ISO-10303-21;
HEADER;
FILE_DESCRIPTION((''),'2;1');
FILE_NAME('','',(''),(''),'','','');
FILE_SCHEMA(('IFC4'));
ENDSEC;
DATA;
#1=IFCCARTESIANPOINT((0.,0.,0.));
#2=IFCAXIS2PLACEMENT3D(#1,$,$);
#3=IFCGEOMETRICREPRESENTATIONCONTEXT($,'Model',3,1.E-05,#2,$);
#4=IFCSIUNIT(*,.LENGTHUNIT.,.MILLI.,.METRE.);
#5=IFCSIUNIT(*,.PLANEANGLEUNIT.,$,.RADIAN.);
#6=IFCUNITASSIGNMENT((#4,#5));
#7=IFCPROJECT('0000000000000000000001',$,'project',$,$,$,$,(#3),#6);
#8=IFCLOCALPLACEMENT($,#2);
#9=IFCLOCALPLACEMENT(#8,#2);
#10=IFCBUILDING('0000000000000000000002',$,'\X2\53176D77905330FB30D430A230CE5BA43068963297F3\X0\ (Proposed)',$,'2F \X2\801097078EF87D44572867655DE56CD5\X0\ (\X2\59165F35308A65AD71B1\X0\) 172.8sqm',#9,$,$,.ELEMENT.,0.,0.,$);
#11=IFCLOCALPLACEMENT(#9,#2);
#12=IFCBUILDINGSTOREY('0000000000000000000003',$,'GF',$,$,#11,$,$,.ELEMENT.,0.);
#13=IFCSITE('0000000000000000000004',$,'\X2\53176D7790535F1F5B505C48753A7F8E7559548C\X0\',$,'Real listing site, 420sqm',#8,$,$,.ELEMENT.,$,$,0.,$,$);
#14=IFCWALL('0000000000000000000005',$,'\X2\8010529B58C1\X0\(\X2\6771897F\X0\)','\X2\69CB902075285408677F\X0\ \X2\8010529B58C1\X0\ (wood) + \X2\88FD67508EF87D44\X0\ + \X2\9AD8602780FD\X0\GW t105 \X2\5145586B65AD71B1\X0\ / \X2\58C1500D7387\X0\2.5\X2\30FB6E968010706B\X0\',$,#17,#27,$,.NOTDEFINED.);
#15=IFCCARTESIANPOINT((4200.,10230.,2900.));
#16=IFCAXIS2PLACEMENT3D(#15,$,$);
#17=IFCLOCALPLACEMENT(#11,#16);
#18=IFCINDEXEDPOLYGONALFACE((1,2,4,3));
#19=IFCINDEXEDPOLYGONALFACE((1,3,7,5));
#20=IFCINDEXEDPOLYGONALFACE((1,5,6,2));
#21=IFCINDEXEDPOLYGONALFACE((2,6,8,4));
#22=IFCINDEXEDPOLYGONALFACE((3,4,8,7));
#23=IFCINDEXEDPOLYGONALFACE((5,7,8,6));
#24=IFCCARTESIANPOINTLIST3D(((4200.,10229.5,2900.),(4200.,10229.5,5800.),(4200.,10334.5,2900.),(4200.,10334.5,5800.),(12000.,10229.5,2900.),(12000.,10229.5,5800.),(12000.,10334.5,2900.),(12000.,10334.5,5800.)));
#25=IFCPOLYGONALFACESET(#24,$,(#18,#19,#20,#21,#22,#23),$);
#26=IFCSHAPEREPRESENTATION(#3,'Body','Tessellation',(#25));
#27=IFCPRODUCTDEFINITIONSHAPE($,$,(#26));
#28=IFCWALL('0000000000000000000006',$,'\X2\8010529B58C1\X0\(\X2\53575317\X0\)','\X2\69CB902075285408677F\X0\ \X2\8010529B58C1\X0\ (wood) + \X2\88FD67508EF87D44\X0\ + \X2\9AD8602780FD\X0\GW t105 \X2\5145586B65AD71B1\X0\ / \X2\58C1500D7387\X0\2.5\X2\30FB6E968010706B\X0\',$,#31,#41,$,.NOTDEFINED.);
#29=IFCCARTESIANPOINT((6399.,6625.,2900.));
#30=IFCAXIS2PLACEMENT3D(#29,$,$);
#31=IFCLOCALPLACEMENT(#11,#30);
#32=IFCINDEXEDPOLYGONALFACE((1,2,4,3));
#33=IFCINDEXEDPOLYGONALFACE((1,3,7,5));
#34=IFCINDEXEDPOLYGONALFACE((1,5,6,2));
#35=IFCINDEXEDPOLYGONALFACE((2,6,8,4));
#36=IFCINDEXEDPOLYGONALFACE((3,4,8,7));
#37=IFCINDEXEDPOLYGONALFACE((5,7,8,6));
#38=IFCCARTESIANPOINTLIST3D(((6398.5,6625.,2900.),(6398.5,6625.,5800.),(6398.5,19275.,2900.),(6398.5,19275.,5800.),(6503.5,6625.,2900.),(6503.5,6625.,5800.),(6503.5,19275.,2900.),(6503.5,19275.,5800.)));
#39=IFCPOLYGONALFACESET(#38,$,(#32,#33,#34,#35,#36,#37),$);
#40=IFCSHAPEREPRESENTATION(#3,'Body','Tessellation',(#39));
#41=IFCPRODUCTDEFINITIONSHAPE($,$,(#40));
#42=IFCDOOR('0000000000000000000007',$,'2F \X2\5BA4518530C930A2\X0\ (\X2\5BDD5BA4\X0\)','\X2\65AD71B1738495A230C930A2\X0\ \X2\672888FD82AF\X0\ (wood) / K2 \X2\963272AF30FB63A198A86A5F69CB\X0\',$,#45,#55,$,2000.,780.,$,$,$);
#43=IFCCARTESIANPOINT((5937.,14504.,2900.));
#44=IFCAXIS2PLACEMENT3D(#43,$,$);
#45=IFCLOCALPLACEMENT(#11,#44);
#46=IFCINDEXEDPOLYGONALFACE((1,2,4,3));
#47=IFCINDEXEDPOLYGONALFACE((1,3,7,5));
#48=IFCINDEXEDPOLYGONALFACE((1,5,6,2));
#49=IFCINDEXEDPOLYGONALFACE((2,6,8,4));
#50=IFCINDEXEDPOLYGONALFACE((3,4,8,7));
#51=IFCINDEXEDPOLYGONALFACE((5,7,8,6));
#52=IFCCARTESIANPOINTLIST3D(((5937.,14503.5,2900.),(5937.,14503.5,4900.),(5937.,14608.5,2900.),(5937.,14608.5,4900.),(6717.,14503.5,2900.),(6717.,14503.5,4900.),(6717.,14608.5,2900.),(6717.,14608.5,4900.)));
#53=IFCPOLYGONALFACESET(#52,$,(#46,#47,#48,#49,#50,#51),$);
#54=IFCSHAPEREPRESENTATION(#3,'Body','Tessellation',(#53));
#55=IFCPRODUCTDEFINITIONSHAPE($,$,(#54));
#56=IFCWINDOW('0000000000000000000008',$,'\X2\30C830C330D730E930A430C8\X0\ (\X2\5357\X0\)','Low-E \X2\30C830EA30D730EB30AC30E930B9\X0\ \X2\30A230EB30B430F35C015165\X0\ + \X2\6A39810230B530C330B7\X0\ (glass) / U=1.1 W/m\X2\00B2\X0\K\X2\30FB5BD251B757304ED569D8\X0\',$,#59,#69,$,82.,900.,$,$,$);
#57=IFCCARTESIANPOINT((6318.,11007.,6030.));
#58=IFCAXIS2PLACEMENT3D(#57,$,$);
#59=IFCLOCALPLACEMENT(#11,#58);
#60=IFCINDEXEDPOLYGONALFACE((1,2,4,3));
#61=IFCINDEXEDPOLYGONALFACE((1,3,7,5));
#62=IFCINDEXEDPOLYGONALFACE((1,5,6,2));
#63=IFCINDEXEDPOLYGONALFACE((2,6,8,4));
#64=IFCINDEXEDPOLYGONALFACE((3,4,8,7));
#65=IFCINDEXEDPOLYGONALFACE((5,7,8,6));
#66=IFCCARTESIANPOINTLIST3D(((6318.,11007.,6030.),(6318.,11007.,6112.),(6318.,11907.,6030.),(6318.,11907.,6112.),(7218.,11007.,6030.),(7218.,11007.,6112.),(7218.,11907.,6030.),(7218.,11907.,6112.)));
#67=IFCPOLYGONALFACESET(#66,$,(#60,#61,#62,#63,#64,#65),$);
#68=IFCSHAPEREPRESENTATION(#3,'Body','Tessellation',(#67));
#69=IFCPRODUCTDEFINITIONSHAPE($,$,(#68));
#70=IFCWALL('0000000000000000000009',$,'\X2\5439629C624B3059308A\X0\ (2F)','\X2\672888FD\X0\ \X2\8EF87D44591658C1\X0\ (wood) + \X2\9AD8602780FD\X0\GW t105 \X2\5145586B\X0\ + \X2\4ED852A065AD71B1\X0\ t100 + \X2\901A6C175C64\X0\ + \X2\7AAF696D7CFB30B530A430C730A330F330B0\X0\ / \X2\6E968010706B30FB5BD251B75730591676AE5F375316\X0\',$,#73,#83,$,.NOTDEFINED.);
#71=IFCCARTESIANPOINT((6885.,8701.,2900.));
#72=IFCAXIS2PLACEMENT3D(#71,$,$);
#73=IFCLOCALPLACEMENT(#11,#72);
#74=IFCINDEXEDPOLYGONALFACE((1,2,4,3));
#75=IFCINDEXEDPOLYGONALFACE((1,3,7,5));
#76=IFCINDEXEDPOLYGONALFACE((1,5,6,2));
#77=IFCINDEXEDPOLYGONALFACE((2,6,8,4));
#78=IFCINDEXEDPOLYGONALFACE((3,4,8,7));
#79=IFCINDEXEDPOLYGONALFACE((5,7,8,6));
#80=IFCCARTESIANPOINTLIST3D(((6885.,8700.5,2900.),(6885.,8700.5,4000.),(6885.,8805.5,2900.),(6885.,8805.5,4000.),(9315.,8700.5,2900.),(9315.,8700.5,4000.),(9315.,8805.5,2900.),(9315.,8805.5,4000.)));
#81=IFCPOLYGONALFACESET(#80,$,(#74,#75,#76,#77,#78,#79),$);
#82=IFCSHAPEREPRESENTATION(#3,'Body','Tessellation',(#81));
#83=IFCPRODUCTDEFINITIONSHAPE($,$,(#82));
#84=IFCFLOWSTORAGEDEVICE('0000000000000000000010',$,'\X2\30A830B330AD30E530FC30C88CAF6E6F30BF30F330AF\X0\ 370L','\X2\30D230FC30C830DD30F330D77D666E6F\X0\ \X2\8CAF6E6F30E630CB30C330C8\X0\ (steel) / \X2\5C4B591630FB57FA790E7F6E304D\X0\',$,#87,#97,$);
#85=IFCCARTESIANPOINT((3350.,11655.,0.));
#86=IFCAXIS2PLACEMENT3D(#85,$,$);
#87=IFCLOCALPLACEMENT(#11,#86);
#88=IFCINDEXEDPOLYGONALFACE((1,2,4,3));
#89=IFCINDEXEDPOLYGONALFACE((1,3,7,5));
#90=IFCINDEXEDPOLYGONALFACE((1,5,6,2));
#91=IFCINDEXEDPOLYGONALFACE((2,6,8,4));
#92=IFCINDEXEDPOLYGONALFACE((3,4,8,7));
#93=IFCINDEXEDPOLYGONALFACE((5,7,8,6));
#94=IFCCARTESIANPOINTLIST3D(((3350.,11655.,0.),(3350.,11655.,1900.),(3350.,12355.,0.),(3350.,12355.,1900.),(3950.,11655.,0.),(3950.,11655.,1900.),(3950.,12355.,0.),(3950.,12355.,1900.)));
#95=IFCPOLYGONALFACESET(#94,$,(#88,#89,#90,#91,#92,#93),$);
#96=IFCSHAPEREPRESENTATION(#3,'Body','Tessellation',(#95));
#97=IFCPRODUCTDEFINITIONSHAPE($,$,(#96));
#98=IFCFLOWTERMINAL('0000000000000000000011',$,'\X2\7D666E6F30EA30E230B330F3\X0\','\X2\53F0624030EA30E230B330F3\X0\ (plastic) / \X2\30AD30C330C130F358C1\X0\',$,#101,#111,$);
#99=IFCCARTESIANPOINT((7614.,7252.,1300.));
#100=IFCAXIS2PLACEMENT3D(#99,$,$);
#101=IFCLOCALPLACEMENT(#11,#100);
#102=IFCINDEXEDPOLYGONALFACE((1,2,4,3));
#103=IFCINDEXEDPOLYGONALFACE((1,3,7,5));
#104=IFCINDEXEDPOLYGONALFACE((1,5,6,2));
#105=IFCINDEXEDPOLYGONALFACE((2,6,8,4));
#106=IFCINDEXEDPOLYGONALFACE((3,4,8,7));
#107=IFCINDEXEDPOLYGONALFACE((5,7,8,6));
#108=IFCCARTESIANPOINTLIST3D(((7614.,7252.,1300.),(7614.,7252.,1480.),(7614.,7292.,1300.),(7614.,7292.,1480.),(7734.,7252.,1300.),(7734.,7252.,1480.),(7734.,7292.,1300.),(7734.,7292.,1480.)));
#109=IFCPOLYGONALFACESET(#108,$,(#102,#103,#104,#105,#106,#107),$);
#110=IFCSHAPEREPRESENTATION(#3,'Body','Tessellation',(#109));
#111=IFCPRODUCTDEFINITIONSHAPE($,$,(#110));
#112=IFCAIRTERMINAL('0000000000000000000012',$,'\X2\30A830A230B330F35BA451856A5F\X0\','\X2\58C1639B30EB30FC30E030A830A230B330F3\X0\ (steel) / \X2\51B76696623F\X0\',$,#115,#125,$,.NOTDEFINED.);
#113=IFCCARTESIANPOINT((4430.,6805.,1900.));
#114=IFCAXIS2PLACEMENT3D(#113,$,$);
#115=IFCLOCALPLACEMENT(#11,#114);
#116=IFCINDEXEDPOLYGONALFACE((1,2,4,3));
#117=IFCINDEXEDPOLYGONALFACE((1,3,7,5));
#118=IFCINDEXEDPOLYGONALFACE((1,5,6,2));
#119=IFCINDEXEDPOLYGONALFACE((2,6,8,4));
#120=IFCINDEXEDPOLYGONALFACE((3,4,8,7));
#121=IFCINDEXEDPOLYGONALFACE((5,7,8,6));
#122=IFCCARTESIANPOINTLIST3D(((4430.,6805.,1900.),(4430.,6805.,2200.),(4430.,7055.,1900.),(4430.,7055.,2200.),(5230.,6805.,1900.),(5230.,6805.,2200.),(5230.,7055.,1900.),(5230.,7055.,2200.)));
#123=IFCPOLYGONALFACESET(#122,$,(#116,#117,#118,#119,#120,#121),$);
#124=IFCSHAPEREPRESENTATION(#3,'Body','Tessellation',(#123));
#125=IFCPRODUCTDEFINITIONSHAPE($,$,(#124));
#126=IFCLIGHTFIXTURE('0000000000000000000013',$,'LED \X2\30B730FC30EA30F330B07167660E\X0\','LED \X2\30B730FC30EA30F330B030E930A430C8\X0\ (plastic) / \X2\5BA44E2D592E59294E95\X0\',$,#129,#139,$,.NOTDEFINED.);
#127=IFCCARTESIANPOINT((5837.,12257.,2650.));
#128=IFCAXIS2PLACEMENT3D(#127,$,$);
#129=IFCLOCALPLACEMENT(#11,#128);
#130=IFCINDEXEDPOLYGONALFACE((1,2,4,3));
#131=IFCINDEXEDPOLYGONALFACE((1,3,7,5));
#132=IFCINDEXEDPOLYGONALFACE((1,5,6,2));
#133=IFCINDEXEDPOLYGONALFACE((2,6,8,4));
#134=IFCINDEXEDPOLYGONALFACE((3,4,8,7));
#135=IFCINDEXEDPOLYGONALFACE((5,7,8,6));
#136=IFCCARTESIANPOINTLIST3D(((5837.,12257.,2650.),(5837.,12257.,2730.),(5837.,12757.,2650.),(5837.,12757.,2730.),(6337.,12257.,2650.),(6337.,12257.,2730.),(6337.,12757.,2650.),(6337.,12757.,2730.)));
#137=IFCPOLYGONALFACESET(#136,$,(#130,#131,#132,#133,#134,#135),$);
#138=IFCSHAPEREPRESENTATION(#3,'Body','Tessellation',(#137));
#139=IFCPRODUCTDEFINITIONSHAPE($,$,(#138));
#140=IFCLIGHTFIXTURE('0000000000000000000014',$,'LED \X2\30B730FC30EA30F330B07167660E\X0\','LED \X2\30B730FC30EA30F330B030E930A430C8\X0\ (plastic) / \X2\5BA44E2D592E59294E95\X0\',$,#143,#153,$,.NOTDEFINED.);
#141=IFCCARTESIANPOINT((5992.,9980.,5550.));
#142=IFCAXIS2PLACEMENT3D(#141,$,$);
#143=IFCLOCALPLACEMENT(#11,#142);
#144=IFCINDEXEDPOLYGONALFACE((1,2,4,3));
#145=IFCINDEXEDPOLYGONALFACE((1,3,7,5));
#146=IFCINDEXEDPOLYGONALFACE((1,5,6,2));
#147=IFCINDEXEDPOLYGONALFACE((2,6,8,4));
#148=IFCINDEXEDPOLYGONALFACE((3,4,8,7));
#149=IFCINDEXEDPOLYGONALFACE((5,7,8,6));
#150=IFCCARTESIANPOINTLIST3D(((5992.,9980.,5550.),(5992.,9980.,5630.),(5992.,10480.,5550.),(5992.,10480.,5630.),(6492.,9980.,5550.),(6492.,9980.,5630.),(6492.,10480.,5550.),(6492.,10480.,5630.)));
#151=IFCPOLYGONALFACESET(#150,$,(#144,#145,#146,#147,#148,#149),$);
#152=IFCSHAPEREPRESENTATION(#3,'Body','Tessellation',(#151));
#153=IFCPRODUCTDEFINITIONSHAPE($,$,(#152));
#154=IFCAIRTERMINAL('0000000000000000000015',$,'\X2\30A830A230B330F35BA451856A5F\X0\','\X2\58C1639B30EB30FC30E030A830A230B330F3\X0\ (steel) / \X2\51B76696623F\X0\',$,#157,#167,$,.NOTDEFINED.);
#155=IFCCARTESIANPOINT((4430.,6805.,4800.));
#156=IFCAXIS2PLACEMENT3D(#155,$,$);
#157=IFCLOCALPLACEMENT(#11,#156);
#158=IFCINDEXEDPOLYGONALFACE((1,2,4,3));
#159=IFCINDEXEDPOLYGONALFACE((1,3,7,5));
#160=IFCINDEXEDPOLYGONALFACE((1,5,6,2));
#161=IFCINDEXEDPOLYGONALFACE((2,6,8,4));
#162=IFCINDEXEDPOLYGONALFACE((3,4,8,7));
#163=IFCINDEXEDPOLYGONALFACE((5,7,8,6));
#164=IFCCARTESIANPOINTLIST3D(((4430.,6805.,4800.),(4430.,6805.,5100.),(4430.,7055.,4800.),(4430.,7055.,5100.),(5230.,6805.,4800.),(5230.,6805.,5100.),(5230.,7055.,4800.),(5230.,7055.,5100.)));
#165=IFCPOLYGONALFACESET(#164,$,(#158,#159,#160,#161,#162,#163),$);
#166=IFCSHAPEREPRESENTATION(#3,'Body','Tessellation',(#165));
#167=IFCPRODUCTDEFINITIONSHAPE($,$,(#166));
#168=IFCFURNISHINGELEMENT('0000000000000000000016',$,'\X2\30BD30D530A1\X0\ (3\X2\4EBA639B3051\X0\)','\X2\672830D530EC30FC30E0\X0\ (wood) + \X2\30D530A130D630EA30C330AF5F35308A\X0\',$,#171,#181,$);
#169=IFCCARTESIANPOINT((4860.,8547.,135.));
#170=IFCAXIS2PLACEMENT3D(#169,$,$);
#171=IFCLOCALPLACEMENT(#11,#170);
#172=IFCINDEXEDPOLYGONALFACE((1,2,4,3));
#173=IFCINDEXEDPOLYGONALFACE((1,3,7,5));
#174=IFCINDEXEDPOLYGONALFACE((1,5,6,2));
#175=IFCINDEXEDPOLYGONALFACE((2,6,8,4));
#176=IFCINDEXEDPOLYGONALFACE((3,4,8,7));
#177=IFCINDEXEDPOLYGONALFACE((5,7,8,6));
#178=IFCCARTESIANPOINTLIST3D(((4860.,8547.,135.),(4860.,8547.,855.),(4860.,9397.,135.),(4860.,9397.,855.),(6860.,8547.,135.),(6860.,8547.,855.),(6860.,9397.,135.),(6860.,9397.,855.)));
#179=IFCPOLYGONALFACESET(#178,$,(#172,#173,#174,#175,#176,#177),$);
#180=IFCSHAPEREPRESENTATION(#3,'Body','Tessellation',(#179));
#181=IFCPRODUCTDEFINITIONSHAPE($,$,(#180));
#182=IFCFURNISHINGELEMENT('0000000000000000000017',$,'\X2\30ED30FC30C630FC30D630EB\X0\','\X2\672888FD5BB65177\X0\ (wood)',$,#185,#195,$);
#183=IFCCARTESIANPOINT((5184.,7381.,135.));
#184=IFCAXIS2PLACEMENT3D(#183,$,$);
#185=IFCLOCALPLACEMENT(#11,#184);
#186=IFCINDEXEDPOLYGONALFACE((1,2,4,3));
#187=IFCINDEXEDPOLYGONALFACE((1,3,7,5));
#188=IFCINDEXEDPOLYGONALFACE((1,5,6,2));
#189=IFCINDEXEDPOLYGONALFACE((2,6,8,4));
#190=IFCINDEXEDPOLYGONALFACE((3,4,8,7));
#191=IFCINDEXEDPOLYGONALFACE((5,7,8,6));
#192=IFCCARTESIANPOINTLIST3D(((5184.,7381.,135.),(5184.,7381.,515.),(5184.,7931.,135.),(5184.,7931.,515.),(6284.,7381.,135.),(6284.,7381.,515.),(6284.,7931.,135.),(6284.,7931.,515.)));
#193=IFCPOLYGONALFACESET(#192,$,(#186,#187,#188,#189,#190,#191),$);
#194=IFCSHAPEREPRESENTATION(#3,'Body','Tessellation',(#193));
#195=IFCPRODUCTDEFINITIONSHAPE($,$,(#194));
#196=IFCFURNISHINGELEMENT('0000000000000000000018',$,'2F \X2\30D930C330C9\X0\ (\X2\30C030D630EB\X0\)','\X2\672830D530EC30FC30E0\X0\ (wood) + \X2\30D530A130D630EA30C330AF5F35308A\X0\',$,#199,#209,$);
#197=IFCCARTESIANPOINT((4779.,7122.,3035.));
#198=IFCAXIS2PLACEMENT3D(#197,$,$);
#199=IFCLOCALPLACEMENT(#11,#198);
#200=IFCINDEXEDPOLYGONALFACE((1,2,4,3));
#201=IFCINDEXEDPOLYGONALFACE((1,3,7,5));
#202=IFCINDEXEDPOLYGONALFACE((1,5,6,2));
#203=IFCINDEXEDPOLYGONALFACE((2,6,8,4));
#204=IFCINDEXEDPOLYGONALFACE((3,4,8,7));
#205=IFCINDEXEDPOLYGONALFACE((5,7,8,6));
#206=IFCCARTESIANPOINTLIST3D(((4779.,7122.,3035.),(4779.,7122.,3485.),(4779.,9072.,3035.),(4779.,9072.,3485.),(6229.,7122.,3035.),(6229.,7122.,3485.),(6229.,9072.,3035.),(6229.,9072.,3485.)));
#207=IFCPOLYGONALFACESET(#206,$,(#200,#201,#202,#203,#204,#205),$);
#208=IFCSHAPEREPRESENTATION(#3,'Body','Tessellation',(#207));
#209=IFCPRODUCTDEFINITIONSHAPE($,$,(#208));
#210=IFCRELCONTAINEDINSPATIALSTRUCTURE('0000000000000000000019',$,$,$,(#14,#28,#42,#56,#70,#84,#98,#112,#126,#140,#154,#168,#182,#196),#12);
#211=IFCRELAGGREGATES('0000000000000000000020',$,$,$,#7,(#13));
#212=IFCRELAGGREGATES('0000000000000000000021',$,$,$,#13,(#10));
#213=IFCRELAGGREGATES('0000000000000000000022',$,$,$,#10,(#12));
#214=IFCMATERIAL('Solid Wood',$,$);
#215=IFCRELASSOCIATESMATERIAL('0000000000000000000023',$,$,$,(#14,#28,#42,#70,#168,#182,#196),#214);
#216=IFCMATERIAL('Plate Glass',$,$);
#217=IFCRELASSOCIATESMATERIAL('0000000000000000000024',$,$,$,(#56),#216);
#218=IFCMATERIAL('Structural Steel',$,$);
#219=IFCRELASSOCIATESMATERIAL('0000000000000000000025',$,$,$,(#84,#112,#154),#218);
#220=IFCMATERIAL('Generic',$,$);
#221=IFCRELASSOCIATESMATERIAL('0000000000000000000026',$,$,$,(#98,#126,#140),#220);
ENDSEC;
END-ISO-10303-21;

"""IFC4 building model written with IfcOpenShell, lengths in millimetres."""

from ifc_helpers import new_model, si_unit, frame, frame_2d, origin, place, context, project, spatial, rectangle, extrude, material, element, fill, save


model = new_model("IFC4")

# Units and contexts
model_context = context("Model", 3, precision=1e-05, world=origin())
ifc_project = project(units=[si_unit("LENGTHUNIT", "METRE", prefix="MILLI"), si_unit("PLANEANGLEUNIT", "RADIAN")], contexts=[model_context])

# Site, building, storey
site_placement = place(None, origin())
site = spatial("IfcSite", under=ifc_project, at=site_placement, Name="北海道弟子屈町美留和", ObjectType="Real listing site, 420sqm", CompositionType="ELEMENT", RefElevation=0.0)
building_placement = place(site_placement, origin())
building = spatial("IfcBuilding", under=site, at=building_placement, Name="北海道・ピアノ室と防音 (Proposed)", ObjectType="2F 耐震軸組在来工法 (外張り断熱) 172.8sqm", CompositionType="ELEMENT", ElevationOfRefHeight=0.0, ElevationOfTerrain=0.0)
storey_placement = place(building_placement, origin())
storey = spatial("IfcBuildingStorey", under=building, at=storey_placement, Name="GF", CompositionType="ELEMENT", Elevation=0.0)

# Shared definitions
ifc_material_1 = material(Name="Solid Wood")

# Wall
wall_1_placement = place(storey_placement, frame((4200.0, 10230.0, 2900.0)))
element("IfcWall", 1, at=wall_1_placement, inside=storey, material=ifc_material_1, Name="耐力壁(東西)", Description="構造用合板 耐力壁 (wood) + 製材軸組 + 高性能GW t105 充填断熱 / 壁倍率2.5・準耐火", PredefinedType="NOTDEFINED", context=model_context, shape_type="SweptSolid", body=[
    extrude(rectangle(XDim=7800.0, YDim=105.0, at=frame_2d((3900.0, 52.0))), frame((4200.0, 10230.0, 2900.0)), (0.0, 0.0, 1.0), 2900.0),
])

# Wall, opening, door
wall_2_placement = place(storey_placement, frame((6399.0, 6625.0, 2900.0)))
wall_2 = element("IfcWall", 2, at=wall_2_placement, inside=storey, material=ifc_material_1, Name="耐力壁(南北)", Description="構造用合板 耐力壁 (wood) + 製材軸組 + 高性能GW t105 充填断熱 / 壁倍率2.5・準耐火", PredefinedType="NOTDEFINED", context=model_context, shape_type="SweptSolid", body=[
    extrude(rectangle(XDim=105.0, YDim=12650.0, at=frame_2d((52.0, 6325.0))), frame((6399.0, 6625.0, 2900.0)), (0.0, 0.0, 1.0), 2900.0),
])
opening_placement = place(storey_placement, frame((5937.0, 14504.0, 2900.0)))
opening = element("IfcOpeningElement", 3, at=opening_placement, cuts=wall_2, PredefinedType="NOTDEFINED", context=model_context, shape_type="SweptSolid", body=[
    extrude(rectangle(XDim=780.0, YDim=105.0, at=frame_2d((390.0, 52.0))), frame((5937.0, 14504.0, 2900.0)), (0.0, 0.0, 1.0), 2000.0),
])
door_placement = place(storey_placement, frame((5937.0, 14504.0, 2900.0)))
door = element("IfcDoor", 4, at=door_placement, inside=storey, material=ifc_material_1, Name="2F 室内ドア (寝室)", Description="断熱玄関ドア 木製芯 (wood) / K2 防犯・採風機構", OverallHeight=2000.0, OverallWidth=780.0, context=model_context, shape_type="SweptSolid", body=[
    extrude(rectangle(XDim=780.0, YDim=105.0, at=frame_2d((390.0, 52.0))), frame((5937.0, 14504.0, 2900.0)), (0.0, 0.0, 1.0), 2000.0),
])
fill(opening, door)

# Window
ifc_material_2 = material(Name="Plate Glass")
window_placement = place(storey_placement, frame((6318.0, 11007.0, 6030.0)))
element("IfcWindow", 5, at=window_placement, inside=storey, material=ifc_material_2, Name="トップライト (南)", Description="Low-E トリプルガラス アルゴン封入 + 樹脂サッシ (glass) / U=1.1 W/m²K・寒冷地仕様", OverallHeight=82.0, OverallWidth=900.0, context=model_context, shape_type="SweptSolid", body=[
    extrude(rectangle(XDim=900.0, YDim=900.0, at=frame_2d((450.0, 450.0))), frame((6318.0, 11007.0, 6030.0)), (0.0, 0.0, 1.0), 82.0),
])

# Wall
wall_3_placement = place(storey_placement, frame((6885.0, 8701.0, 2900.0)))
element("IfcWall", 6, at=wall_3_placement, inside=storey, material=ifc_material_1, Name="吹抜手すり (2F)", Description="木製 軸組外壁 (wood) + 高性能GW t105 充填 + 付加断熱 t100 + 通気層 + 窯業系サイディング / 準耐火・寒冷地外皮強化", PredefinedType="NOTDEFINED", context=model_context, shape_type="SweptSolid", body=[
    extrude(rectangle(XDim=2430.0, YDim=105.0, at=frame_2d((1215.0, 52.0))), frame((6885.0, 8701.0, 2900.0)), (0.0, 0.0, 1.0), 1100.0),
])

# Flow storage device
ifc_material_3 = material(Name="Structural Steel")
flow_storage_device_placement = place(storey_placement, frame((3350.0, 11655.0, 0.0)))
element("IfcFlowStorageDevice", 7, at=flow_storage_device_placement, inside=storey, material=ifc_material_3, Name="エコキュート貯湯タンク 370L", Description="ヒートポンプ給湯 貯湯ユニット (steel) / 屋外・基礎置き", context=model_context, shape_type="SweptSolid", body=[
    extrude(rectangle(XDim=600.0, YDim=700.0, at=frame_2d((300.0, 350.0))), frame((3350.0, 11655.0, 0.0)), (0.0, 0.0, 1.0), 1900.0),
])

# Flow terminal
ifc_material_4 = material(Name="Generic")
flow_terminal_placement = place(storey_placement, frame((7614.0, 7252.0, 1300.0)))
element("IfcFlowTerminal", 8, at=flow_terminal_placement, inside=storey, material=ifc_material_4, Name="給湯リモコン", Description="台所リモコン (plastic) / キッチン壁", context=model_context, shape_type="SweptSolid", body=[
    extrude(rectangle(XDim=120.0, YDim=40.0, at=frame_2d((60.0, 20.0))), frame((7614.0, 7252.0, 1300.0)), (0.0, 0.0, 1.0), 180.0),
])

# Air terminal
air_terminal_1_placement = place(storey_placement, frame((4430.0, 6805.0, 1900.0)))
element("IfcAirTerminal", 9, at=air_terminal_1_placement, inside=storey, material=ifc_material_3, Name="エアコン室内機", Description="壁掛ルームエアコン (steel) / 冷暖房", PredefinedType="NOTDEFINED", context=model_context, shape_type="SweptSolid", body=[
    extrude(rectangle(XDim=800.0, YDim=250.0, at=frame_2d((400.0, 125.0))), frame((4430.0, 6805.0, 1900.0)), (0.0, 0.0, 1.0), 300.0),
])

# Light fixtures
light_fixture_1_placement = place(storey_placement, frame((5837.0, 12257.0, 2650.0)))
element("IfcLightFixture", 10, at=light_fixture_1_placement, inside=storey, material=ifc_material_4, Name="LED シーリング照明", Description="LED シーリングライト (plastic) / 室中央天井", PredefinedType="NOTDEFINED", context=model_context, shape_type="SweptSolid", body=[
    extrude(rectangle(XDim=500.0, YDim=500.0, at=frame_2d((250.0, 250.0))), frame((5837.0, 12257.0, 2650.0)), (0.0, 0.0, 1.0), 80.0),
])
light_fixture_2_placement = place(storey_placement, frame((5992.0, 9980.0, 5550.0)))
element("IfcLightFixture", 11, at=light_fixture_2_placement, inside=storey, material=ifc_material_4, Name="LED シーリング照明", Description="LED シーリングライト (plastic) / 室中央天井", PredefinedType="NOTDEFINED", context=model_context, shape_type="SweptSolid", body=[
    extrude(rectangle(XDim=500.0, YDim=500.0, at=frame_2d((250.0, 250.0))), frame((5992.0, 9980.0, 5550.0)), (0.0, 0.0, 1.0), 80.0),
])

# Air terminal
air_terminal_2_placement = place(storey_placement, frame((4430.0, 6805.0, 4800.0)))
element("IfcAirTerminal", 12, at=air_terminal_2_placement, inside=storey, material=ifc_material_3, Name="エアコン室内機", Description="壁掛ルームエアコン (steel) / 冷暖房", PredefinedType="NOTDEFINED", context=model_context, shape_type="SweptSolid", body=[
    extrude(rectangle(XDim=800.0, YDim=250.0, at=frame_2d((400.0, 125.0))), frame((4430.0, 6805.0, 4800.0)), (0.0, 0.0, 1.0), 300.0),
])

# Furnishing elements
furnishing_1_placement = place(storey_placement, frame((4860.0, 8547.0, 135.0)))
element("IfcFurnishingElement", 13, at=furnishing_1_placement, inside=storey, material=ifc_material_1, Name="ソファ (3人掛け)", Description="木フレーム (wood) + ファブリック張り", context=model_context, shape_type="SweptSolid", body=[
    extrude(rectangle(XDim=2000.0, YDim=850.0, at=frame_2d((1000.0, 425.0))), frame((4860.0, 8547.0, 135.0)), (0.0, 0.0, 1.0), 720.0),
])
furnishing_2_placement = place(storey_placement, frame((5184.0, 7381.0, 135.0)))
element("IfcFurnishingElement", 14, at=furnishing_2_placement, inside=storey, material=ifc_material_1, Name="ローテーブル", Description="木製家具 (wood)", context=model_context, shape_type="SweptSolid", body=[
    extrude(rectangle(XDim=1100.0, YDim=550.0, at=frame_2d((550.0, 275.0))), frame((5184.0, 7381.0, 135.0)), (0.0, 0.0, 1.0), 380.0),
])
furnishing_3_placement = place(storey_placement, frame((4779.0, 7122.0, 3035.0)))
element("IfcFurnishingElement", 15, at=furnishing_3_placement, inside=storey, material=ifc_material_1, Name="2F ベッド (ダブル)", Description="木フレーム (wood) + ファブリック張り", context=model_context, shape_type="SweptSolid", body=[
    extrude(rectangle(XDim=1450.0, YDim=1950.0, at=frame_2d((725.0, 975.0))), frame((4779.0, 7122.0, 3035.0)), (0.0, 0.0, 1.0), 450.0),
])

save(model, "model.ifc")
